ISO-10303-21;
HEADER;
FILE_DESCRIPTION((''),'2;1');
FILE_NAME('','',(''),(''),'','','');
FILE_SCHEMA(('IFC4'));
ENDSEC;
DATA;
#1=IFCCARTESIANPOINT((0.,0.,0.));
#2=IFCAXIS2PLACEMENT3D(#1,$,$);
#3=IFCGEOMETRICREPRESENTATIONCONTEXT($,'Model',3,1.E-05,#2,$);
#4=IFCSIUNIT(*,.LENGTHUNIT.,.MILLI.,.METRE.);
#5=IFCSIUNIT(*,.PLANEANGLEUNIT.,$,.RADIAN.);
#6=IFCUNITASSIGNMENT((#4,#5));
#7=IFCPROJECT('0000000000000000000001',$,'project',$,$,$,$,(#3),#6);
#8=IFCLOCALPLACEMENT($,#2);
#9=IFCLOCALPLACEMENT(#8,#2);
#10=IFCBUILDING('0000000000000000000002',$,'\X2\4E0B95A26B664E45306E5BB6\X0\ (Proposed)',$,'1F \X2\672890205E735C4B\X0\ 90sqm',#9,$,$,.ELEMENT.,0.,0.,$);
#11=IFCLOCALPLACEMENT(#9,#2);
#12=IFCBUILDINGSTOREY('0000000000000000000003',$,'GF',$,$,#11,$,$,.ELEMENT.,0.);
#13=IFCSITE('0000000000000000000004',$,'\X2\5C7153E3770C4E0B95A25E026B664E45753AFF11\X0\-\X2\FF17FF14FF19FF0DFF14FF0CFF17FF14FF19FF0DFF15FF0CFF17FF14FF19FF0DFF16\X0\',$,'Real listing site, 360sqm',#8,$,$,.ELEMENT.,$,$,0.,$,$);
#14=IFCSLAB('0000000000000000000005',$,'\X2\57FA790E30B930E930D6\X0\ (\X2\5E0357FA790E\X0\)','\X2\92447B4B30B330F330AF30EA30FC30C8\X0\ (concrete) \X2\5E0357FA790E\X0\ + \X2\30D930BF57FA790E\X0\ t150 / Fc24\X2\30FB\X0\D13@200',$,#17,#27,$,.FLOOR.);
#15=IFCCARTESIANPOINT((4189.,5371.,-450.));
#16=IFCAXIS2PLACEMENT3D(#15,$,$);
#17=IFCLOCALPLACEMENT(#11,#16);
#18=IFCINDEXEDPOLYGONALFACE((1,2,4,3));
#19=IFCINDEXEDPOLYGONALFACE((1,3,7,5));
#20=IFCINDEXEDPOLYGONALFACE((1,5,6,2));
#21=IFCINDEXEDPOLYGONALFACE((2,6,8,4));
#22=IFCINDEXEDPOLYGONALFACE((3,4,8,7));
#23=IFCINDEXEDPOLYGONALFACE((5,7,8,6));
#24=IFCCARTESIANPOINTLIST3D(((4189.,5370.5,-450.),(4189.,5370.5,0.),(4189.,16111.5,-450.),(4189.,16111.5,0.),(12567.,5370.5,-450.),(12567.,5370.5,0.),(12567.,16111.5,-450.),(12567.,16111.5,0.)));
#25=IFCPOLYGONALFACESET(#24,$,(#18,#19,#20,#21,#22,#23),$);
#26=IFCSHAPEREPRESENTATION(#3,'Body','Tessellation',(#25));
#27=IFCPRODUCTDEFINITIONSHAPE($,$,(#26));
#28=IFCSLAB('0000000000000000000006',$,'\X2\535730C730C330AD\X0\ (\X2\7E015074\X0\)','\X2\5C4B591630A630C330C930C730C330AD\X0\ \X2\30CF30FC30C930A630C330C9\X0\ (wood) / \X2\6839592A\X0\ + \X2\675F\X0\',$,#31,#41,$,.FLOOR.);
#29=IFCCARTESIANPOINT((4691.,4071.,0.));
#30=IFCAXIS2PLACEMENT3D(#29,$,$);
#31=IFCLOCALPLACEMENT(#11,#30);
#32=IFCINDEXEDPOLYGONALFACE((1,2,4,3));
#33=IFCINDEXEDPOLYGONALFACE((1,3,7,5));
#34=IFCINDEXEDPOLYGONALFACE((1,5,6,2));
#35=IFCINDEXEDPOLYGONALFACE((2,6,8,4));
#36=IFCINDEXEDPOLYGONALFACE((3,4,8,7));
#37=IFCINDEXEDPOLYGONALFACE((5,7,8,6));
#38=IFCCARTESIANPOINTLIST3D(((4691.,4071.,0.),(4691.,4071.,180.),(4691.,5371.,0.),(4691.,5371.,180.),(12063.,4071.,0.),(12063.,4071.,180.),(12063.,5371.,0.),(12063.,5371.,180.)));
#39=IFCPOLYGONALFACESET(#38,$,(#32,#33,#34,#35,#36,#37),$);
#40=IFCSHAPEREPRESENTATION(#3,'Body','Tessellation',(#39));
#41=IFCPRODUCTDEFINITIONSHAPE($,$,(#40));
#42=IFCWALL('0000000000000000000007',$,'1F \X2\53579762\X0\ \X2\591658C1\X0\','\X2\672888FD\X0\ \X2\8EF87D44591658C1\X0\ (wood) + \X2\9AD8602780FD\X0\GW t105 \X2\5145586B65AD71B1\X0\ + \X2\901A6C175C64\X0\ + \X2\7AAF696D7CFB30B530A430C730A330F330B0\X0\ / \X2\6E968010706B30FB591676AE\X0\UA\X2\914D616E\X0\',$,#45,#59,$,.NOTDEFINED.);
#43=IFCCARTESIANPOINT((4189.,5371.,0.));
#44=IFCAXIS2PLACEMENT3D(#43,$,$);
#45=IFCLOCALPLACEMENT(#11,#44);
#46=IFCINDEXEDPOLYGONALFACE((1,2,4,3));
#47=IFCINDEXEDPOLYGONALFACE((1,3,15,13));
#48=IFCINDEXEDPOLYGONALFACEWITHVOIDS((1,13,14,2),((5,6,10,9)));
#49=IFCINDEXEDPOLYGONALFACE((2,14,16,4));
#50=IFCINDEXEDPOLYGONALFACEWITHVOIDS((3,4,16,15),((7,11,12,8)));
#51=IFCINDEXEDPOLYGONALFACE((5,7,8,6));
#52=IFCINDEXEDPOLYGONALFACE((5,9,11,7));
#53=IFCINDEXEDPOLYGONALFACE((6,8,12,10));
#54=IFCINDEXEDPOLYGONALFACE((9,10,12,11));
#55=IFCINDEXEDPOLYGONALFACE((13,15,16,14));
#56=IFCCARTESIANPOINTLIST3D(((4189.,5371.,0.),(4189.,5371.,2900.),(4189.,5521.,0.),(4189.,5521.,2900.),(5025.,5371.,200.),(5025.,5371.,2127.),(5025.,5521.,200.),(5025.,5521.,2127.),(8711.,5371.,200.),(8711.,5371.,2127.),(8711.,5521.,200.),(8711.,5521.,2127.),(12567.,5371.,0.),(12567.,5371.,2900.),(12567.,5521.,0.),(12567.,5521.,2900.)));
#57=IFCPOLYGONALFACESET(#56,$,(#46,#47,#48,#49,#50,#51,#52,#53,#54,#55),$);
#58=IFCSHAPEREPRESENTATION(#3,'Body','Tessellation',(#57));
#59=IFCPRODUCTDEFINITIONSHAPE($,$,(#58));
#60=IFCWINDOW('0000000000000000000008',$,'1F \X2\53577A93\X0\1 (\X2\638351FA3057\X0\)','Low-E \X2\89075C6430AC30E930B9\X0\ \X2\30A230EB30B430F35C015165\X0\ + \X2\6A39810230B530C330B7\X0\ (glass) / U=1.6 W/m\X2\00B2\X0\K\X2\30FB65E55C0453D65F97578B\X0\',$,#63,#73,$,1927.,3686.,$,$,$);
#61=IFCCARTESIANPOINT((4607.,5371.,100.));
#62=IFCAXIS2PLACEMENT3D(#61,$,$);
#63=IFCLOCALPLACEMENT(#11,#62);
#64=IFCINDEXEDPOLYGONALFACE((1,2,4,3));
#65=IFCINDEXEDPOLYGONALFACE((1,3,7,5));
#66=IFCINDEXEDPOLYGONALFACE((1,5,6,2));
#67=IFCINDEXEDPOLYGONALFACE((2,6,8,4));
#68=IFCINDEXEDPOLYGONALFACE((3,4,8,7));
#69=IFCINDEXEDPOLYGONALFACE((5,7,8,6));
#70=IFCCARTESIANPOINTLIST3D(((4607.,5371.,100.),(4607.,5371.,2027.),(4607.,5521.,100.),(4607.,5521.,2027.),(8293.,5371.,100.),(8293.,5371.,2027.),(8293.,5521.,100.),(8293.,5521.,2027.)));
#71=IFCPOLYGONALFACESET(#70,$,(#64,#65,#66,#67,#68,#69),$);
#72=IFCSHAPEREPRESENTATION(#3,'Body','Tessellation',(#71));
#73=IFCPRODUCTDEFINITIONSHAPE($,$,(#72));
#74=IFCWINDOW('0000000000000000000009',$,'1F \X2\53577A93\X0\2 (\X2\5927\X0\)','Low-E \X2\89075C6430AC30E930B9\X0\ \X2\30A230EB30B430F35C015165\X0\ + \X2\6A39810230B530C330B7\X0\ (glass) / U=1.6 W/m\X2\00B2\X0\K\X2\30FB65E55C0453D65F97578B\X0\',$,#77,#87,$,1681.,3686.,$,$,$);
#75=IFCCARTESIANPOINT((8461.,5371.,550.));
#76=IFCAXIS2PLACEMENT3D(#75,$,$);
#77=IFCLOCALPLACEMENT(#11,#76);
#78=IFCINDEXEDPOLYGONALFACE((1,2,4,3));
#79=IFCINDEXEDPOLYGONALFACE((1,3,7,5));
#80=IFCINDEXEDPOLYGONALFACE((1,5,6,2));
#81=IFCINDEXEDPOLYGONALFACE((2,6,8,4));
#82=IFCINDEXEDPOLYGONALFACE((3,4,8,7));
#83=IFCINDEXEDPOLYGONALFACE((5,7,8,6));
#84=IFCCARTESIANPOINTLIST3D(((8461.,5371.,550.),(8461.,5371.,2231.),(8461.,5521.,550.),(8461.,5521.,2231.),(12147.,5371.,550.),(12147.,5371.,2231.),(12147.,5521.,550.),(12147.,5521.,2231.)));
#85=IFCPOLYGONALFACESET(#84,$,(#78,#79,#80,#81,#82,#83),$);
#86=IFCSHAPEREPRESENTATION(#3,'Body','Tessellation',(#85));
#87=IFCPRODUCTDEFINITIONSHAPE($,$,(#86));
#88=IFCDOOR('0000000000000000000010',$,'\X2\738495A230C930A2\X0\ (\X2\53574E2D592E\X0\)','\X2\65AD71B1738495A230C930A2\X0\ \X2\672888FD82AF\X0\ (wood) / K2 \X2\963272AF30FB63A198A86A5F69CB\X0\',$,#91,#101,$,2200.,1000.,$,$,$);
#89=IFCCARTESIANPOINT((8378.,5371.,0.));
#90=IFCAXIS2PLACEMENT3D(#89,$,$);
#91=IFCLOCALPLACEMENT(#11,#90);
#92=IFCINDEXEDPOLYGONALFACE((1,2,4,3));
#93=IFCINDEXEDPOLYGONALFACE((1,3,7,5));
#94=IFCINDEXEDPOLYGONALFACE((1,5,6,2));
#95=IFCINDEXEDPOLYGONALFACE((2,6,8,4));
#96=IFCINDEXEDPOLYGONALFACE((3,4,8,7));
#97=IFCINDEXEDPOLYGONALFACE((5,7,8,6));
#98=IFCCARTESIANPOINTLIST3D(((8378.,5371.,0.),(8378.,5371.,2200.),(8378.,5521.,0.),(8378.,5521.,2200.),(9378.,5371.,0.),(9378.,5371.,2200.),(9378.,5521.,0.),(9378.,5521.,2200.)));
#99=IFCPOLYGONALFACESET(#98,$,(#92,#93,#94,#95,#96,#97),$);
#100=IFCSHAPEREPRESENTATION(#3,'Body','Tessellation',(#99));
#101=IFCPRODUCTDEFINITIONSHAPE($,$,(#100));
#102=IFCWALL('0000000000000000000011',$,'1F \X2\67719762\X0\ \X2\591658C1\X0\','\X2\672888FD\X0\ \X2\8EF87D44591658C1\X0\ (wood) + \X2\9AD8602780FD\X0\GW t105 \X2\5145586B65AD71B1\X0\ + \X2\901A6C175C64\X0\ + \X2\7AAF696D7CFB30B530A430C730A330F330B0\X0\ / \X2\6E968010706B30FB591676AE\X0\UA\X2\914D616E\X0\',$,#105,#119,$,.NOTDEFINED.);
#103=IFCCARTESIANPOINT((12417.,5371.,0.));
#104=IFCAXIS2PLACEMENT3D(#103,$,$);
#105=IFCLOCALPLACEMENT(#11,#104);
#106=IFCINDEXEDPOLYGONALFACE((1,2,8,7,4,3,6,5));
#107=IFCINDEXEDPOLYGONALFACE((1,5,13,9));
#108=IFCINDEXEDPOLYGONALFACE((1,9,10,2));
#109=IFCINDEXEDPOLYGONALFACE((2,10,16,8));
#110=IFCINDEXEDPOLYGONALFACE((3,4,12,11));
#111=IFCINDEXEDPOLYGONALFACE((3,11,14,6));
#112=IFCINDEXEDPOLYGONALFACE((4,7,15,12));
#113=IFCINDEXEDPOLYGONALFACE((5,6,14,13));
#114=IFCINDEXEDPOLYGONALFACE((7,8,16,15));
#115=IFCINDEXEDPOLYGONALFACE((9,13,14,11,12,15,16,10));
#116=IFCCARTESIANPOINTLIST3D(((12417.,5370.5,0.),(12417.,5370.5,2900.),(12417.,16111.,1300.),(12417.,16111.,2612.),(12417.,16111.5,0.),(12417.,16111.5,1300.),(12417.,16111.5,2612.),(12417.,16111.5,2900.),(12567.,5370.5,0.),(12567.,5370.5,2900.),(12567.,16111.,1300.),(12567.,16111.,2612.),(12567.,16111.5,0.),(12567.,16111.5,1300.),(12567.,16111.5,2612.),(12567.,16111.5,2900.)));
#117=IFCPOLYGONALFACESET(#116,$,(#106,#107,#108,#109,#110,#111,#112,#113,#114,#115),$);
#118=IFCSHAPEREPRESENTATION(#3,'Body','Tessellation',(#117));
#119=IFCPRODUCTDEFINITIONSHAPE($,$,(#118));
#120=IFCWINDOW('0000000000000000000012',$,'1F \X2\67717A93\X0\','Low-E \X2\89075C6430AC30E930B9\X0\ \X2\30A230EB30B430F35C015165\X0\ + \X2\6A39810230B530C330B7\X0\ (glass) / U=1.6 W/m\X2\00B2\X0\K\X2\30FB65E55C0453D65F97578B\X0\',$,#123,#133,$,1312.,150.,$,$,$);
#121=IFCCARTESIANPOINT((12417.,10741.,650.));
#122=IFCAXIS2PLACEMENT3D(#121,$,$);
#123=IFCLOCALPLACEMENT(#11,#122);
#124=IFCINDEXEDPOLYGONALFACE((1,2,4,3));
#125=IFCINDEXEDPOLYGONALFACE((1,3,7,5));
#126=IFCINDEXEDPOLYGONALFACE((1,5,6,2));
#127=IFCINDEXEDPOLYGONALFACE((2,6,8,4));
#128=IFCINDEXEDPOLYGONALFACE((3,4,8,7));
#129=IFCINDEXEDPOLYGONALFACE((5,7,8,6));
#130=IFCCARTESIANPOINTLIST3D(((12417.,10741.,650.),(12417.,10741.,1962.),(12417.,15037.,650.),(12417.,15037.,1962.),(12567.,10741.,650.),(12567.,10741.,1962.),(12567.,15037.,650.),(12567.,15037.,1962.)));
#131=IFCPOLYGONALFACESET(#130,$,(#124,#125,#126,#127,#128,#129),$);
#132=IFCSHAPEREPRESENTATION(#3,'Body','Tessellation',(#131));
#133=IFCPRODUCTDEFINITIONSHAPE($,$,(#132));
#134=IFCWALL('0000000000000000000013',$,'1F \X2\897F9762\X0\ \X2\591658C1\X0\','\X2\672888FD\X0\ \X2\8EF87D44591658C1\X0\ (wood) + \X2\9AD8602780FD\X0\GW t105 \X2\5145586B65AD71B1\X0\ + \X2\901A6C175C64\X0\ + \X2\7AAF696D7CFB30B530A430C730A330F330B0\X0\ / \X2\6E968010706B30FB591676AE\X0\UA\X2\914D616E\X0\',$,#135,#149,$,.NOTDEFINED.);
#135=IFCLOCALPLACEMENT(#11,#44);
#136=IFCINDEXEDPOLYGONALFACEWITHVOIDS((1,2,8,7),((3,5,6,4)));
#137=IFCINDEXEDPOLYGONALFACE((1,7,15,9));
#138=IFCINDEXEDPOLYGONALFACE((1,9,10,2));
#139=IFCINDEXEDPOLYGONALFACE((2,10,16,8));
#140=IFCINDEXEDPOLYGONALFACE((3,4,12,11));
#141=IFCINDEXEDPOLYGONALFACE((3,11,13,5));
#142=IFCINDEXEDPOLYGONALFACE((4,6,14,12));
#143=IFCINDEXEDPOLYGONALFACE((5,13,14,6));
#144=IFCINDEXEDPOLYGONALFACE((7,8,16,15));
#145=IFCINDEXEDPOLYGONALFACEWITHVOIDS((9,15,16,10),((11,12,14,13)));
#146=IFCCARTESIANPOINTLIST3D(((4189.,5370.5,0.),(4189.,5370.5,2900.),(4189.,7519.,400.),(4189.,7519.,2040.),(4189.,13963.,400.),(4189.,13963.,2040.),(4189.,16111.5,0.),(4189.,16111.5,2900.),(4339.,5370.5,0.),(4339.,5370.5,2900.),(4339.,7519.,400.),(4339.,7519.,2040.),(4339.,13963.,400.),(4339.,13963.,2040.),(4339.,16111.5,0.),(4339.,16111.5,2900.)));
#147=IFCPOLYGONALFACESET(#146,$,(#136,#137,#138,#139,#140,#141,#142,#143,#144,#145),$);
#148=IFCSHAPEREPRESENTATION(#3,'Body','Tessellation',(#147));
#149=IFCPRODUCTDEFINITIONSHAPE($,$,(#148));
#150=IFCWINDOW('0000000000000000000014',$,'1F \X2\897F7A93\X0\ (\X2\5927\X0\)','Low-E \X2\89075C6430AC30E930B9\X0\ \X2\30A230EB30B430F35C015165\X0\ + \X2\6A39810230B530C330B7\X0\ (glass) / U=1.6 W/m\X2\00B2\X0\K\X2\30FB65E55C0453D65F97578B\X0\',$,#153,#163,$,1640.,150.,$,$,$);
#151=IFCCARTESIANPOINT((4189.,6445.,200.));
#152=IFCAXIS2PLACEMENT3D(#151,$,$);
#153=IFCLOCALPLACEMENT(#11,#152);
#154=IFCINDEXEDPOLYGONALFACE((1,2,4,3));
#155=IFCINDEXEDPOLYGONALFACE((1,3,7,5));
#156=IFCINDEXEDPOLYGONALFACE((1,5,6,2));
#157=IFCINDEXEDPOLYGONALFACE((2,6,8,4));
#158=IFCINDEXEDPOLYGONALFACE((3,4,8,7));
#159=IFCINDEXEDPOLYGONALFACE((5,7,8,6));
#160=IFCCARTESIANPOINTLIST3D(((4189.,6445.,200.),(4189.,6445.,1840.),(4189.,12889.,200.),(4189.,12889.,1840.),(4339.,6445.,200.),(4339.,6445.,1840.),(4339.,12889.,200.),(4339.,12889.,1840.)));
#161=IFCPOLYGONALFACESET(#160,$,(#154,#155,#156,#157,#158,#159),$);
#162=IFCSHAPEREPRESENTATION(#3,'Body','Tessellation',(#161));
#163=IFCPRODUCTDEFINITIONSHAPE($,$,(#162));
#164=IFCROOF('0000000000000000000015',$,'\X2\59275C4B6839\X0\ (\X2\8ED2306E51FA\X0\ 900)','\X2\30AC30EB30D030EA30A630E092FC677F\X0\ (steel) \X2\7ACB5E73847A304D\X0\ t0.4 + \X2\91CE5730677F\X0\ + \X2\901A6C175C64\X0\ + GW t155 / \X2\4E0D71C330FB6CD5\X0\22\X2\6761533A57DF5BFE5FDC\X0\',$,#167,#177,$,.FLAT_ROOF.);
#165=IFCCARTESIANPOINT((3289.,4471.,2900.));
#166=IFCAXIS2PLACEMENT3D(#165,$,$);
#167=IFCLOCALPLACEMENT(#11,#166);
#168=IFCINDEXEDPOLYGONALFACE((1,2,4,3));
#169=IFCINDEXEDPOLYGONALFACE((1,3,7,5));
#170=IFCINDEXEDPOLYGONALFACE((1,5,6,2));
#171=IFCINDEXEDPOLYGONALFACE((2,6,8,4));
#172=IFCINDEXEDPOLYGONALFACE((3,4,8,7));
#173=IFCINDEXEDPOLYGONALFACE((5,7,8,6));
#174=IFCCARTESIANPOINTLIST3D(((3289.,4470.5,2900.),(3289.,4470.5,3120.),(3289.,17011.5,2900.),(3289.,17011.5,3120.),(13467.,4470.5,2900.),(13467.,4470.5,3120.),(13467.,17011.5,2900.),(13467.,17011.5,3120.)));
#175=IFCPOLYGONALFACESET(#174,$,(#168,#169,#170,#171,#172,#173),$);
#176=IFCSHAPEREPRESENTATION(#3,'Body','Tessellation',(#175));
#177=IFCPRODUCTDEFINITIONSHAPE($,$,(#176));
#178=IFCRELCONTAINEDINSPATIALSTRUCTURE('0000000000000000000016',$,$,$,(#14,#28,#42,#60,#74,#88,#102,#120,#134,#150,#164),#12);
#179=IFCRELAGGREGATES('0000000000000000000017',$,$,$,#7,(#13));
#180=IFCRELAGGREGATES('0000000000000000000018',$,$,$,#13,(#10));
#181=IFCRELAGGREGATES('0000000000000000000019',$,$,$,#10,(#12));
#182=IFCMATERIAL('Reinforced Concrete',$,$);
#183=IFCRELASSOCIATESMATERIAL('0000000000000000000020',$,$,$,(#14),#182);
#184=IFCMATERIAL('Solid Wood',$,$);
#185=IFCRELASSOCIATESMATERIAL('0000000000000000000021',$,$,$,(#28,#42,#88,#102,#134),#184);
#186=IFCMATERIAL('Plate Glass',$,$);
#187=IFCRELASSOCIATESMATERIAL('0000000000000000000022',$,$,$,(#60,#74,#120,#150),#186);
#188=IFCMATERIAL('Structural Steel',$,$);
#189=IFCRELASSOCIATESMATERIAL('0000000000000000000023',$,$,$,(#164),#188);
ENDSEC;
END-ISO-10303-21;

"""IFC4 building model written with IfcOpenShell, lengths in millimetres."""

from ifc_helpers import new_model, si_unit, frame, frame_2d, origin, place, context, project, spatial, rectangle, extrude, material, element, fill, save


model = new_model("IFC4")

# Units and contexts
model_context = context("Model", 3, precision=1e-05, world=origin())
ifc_project = project(units=[si_unit("LENGTHUNIT", "METRE", prefix="MILLI"), si_unit("PLANEANGLEUNIT", "RADIAN")], contexts=[model_context])

# Site, building, storey
site_placement = place(None, origin())
site = spatial("IfcSite", under=ifc_project, at=site_placement, Name="山口県下関市武久町１-７４９－４，７４９－５，７４９－６", ObjectType="Real listing site, 360sqm", CompositionType="ELEMENT", RefElevation=0.0)
building_placement = place(site_placement, origin())
building = spatial("IfcBuilding", under=site, at=building_placement, Name="下関武久の家 (Proposed)", ObjectType="1F 木造平屋 90sqm", CompositionType="ELEMENT", ElevationOfRefHeight=0.0, ElevationOfTerrain=0.0)
storey_placement = place(building_placement, origin())
storey = spatial("IfcBuildingStorey", under=building, at=storey_placement, Name="GF", CompositionType="ELEMENT", Elevation=0.0)

# Slabs
ifc_material_1 = material(Name="Reinforced Concrete")
slab_1_placement = place(storey_placement, frame((4189.0, 5371.0, -450.0)))
element("IfcSlab", 1, at=slab_1_placement, inside=storey, material=ifc_material_1, Name="基礎スラブ (布基礎)", Description="鉄筋コンクリート (concrete) 布基礎 + ベタ基礎 t150 / Fc24・D13@200", PredefinedType="FLOOR", context=model_context, shape_type="SweptSolid", body=[
    extrude(rectangle(XDim=8378.0, YDim=10741.0, at=frame_2d((4189.0, 5370.0))), frame((4189.0, 5371.0, -450.0)), (0.0, 0.0, 1.0), 450.0),
])
ifc_material_2 = material(Name="Solid Wood")
slab_2_placement = place(storey_placement, frame((4691.0, 4071.0, 0.0)))
element("IfcSlab", 2, at=slab_2_placement, inside=storey, material=ifc_material_2, Name="南デッキ (縁側)", Description="屋外ウッドデッキ ハードウッド (wood) / 根太 + 束", PredefinedType="FLOOR", context=model_context, shape_type="SweptSolid", body=[
    extrude(rectangle(XDim=7372.0, YDim=1300.0, at=frame_2d((3686.0, 650.0))), frame((4691.0, 4071.0, 0.0)), (0.0, 0.0, 1.0), 180.0),
])

# Wall, openings, windows, door
wall_1_placement = place(storey_placement, frame((4189.0, 5371.0, 0.0)))
wall_1 = element("IfcWall", 3, at=wall_1_placement, inside=storey, material=ifc_material_2, Name="1F 南面 外壁", Description="木製 軸組外壁 (wood) + 高性能GW t105 充填断熱 + 通気層 + 窯業系サイディング / 準耐火・外皮UA配慮", PredefinedType="NOTDEFINED", context=model_context, shape_type="SweptSolid", body=[
    extrude(rectangle(XDim=8378.0, YDim=150.0, at=frame_2d((4189.0, 75.0))), frame((4189.0, 5371.0, 0.0)), (0.0, 0.0, 1.0), 2900.0),
])
opening_1_placement = place(storey_placement, frame((4607.0, 5371.0, 100.0)))
opening_1 = element("IfcOpeningElement", 4, at=opening_1_placement, cuts=wall_1, PredefinedType="NOTDEFINED", context=model_context, shape_type="SweptSolid", body=[
    extrude(rectangle(XDim=3686.0, YDim=150.0, at=frame_2d((1843.0, 75.0))), frame((4607.0, 5371.0, 100.0)), (0.0, 0.0, 1.0), 1927.0),
])
opening_2_placement = place(storey_placement, frame((8461.0, 5371.0, 550.0)))
opening_2 = element("IfcOpeningElement", 5, at=opening_2_placement, cuts=wall_1, PredefinedType="NOTDEFINED", context=model_context, shape_type="SweptSolid", body=[
    extrude(rectangle(XDim=3686.0, YDim=150.0, at=frame_2d((1843.0, 75.0))), frame((8461.0, 5371.0, 550.0)), (0.0, 0.0, 1.0), 1681.0),
])
opening_3_placement = place(storey_placement, frame((8378.0, 5371.0, 0.0)))
opening_3 = element("IfcOpeningElement", 6, at=opening_3_placement, cuts=wall_1, PredefinedType="NOTDEFINED", context=model_context, shape_type="SweptSolid", body=[
    extrude(rectangle(XDim=1000.0, YDim=150.0, at=frame_2d((500.0, 75.0))), frame((8378.0, 5371.0, 0.0)), (0.0, 0.0, 1.0), 2200.0),
])
ifc_material_3 = material(Name="Plate Glass")
window_1_placement = place(storey_placement, frame((4607.0, 5371.0, 100.0)))
window_1 = element("IfcWindow", 7, at=window_1_placement, inside=storey, material=ifc_material_3, Name="1F 南窓1 (掃出し)", Description="Low-E 複層ガラス アルゴン封入 + 樹脂サッシ (glass) / U=1.6 W/m²K・日射取得型", OverallHeight=1927.0, OverallWidth=3686.0, context=model_context, shape_type="SweptSolid", body=[
    extrude(rectangle(XDim=3686.0, YDim=150.0, at=frame_2d((1843.0, 75.0))), frame((4607.0, 5371.0, 100.0)), (0.0, 0.0, 1.0), 1927.0),
])
fill(opening_1, window_1)
window_2_placement = place(storey_placement, frame((8461.0, 5371.0, 550.0)))
window_2 = element("IfcWindow", 8, at=window_2_placement, inside=storey, material=ifc_material_3, Name="1F 南窓2 (大)", Description="Low-E 複層ガラス アルゴン封入 + 樹脂サッシ (glass) / U=1.6 W/m²K・日射取得型", OverallHeight=1681.0, OverallWidth=3686.0, context=model_context, shape_type="SweptSolid", body=[
    extrude(rectangle(XDim=3686.0, YDim=150.0, at=frame_2d((1843.0, 75.0))), frame((8461.0, 5371.0, 550.0)), (0.0, 0.0, 1.0), 1681.0),
])
fill(opening_2, window_2)
door_placement = place(storey_placement, frame((8378.0, 5371.0, 0.0)))
door = element("IfcDoor", 9, at=door_placement, inside=storey, material=ifc_material_2, Name="玄関ドア (南中央)", Description="断熱玄関ドア 木製芯 (wood) / K2 防犯・採風機構", OverallHeight=2200.0, OverallWidth=1000.0, context=model_context, shape_type="SweptSolid", body=[
    extrude(rectangle(XDim=1000.0, YDim=150.0, at=frame_2d((500.0, 75.0))), frame((8378.0, 5371.0, 0.0)), (0.0, 0.0, 1.0), 2200.0),
])
fill(opening_3, door)

# Walls, openings, windows
wall_2_placement = place(storey_placement, frame((12417.0, 5371.0, 0.0)))
wall_2 = element("IfcWall", 10, at=wall_2_placement, inside=storey, material=ifc_material_2, Name="1F 東面 外壁", Description="木製 軸組外壁 (wood) + 高性能GW t105 充填断熱 + 通気層 + 窯業系サイディング / 準耐火・外皮UA配慮", PredefinedType="NOTDEFINED", context=model_context, shape_type="SweptSolid", body=[
    extrude(rectangle(XDim=150.0, YDim=10741.0, at=frame_2d((75.0, 5370.0))), frame((12417.0, 5371.0, 0.0)), (0.0, 0.0, 1.0), 2900.0),
])
opening_4_placement = place(storey_placement, frame((12417.0, 10741.0, 650.0)))
opening_4 = element("IfcOpeningElement", 11, at=opening_4_placement, cuts=wall_2, PredefinedType="NOTDEFINED", context=model_context, shape_type="SweptSolid", body=[
    extrude(rectangle(XDim=150.0, YDim=4296.0, at=frame_2d((75.0, 2148.0))), frame((12417.0, 10741.0, 650.0)), (0.0, 0.0, 1.0), 1312.0),
])
window_3_placement = place(storey_placement, frame((12417.0, 10741.0, 650.0)))
window_3 = element("IfcWindow", 12, at=window_3_placement, inside=storey, material=ifc_material_3, Name="1F 東窓", Description="Low-E 複層ガラス アルゴン封入 + 樹脂サッシ (glass) / U=1.6 W/m²K・日射取得型", OverallHeight=1312.0, OverallWidth=150.0, context=model_context, shape_type="SweptSolid", body=[
    extrude(rectangle(XDim=150.0, YDim=4296.0, at=frame_2d((75.0, 2148.0))), frame((12417.0, 10741.0, 650.0)), (0.0, 0.0, 1.0), 1312.0),
])
fill(opening_4, window_3)
wall_3_placement = place(storey_placement, frame((4189.0, 5371.0, 0.0)))
wall_3 = element("IfcWall", 13, at=wall_3_placement, inside=storey, material=ifc_material_2, Name="1F 西面 外壁", Description="木製 軸組外壁 (wood) + 高性能GW t105 充填断熱 + 通気層 + 窯業系サイディング / 準耐火・外皮UA配慮", PredefinedType="NOTDEFINED", context=model_context, shape_type="SweptSolid", body=[
    extrude(rectangle(XDim=150.0, YDim=10741.0, at=frame_2d((75.0, 5370.0))), frame((4189.0, 5371.0, 0.0)), (0.0, 0.0, 1.0), 2900.0),
])
opening_5_placement = place(storey_placement, frame((4189.0, 6445.0, 200.0)))
opening_5 = element("IfcOpeningElement", 14, at=opening_5_placement, cuts=wall_3, PredefinedType="NOTDEFINED", context=model_context, shape_type="SweptSolid", body=[
    extrude(rectangle(XDim=150.0, YDim=6444.0, at=frame_2d((75.0, 3222.0))), frame((4189.0, 6445.0, 200.0)), (0.0, 0.0, 1.0), 1640.0),
])
window_4_placement = place(storey_placement, frame((4189.0, 6445.0, 200.0)))
window_4 = element("IfcWindow", 15, at=window_4_placement, inside=storey, material=ifc_material_3, Name="1F 西窓 (大)", Description="Low-E 複層ガラス アルゴン封入 + 樹脂サッシ (glass) / U=1.6 W/m²K・日射取得型", OverallHeight=1640.0, OverallWidth=150.0, context=model_context, shape_type="SweptSolid", body=[
    extrude(rectangle(XDim=150.0, YDim=6444.0, at=frame_2d((75.0, 3222.0))), frame((4189.0, 6445.0, 200.0)), (0.0, 0.0, 1.0), 1640.0),
])
fill(opening_5, window_4)

# Roof
ifc_material_4 = material(Name="Structural Steel")
roof_placement = place(storey_placement, frame((3289.0, 4471.0, 2900.0)))
element("IfcRoof", 16, at=roof_placement, inside=storey, material=ifc_material_4, Name="大屋根 (軒の出 900)", Description="ガルバリウム鋼板 (steel) 立平葺き t0.4 + 野地板 + 通気層 + GW t155 / 不燃・法22条区域対応", PredefinedType="FLAT_ROOF", context=model_context, shape_type="SweptSolid", body=[
    extrude(rectangle(XDim=10178.0, YDim=12541.0, at=frame_2d((5089.0, 6270.0))), frame((3289.0, 4471.0, 2900.0)), (0.0, 0.0, 1.0), 220.0),
])

save(model, "model.ifc")
